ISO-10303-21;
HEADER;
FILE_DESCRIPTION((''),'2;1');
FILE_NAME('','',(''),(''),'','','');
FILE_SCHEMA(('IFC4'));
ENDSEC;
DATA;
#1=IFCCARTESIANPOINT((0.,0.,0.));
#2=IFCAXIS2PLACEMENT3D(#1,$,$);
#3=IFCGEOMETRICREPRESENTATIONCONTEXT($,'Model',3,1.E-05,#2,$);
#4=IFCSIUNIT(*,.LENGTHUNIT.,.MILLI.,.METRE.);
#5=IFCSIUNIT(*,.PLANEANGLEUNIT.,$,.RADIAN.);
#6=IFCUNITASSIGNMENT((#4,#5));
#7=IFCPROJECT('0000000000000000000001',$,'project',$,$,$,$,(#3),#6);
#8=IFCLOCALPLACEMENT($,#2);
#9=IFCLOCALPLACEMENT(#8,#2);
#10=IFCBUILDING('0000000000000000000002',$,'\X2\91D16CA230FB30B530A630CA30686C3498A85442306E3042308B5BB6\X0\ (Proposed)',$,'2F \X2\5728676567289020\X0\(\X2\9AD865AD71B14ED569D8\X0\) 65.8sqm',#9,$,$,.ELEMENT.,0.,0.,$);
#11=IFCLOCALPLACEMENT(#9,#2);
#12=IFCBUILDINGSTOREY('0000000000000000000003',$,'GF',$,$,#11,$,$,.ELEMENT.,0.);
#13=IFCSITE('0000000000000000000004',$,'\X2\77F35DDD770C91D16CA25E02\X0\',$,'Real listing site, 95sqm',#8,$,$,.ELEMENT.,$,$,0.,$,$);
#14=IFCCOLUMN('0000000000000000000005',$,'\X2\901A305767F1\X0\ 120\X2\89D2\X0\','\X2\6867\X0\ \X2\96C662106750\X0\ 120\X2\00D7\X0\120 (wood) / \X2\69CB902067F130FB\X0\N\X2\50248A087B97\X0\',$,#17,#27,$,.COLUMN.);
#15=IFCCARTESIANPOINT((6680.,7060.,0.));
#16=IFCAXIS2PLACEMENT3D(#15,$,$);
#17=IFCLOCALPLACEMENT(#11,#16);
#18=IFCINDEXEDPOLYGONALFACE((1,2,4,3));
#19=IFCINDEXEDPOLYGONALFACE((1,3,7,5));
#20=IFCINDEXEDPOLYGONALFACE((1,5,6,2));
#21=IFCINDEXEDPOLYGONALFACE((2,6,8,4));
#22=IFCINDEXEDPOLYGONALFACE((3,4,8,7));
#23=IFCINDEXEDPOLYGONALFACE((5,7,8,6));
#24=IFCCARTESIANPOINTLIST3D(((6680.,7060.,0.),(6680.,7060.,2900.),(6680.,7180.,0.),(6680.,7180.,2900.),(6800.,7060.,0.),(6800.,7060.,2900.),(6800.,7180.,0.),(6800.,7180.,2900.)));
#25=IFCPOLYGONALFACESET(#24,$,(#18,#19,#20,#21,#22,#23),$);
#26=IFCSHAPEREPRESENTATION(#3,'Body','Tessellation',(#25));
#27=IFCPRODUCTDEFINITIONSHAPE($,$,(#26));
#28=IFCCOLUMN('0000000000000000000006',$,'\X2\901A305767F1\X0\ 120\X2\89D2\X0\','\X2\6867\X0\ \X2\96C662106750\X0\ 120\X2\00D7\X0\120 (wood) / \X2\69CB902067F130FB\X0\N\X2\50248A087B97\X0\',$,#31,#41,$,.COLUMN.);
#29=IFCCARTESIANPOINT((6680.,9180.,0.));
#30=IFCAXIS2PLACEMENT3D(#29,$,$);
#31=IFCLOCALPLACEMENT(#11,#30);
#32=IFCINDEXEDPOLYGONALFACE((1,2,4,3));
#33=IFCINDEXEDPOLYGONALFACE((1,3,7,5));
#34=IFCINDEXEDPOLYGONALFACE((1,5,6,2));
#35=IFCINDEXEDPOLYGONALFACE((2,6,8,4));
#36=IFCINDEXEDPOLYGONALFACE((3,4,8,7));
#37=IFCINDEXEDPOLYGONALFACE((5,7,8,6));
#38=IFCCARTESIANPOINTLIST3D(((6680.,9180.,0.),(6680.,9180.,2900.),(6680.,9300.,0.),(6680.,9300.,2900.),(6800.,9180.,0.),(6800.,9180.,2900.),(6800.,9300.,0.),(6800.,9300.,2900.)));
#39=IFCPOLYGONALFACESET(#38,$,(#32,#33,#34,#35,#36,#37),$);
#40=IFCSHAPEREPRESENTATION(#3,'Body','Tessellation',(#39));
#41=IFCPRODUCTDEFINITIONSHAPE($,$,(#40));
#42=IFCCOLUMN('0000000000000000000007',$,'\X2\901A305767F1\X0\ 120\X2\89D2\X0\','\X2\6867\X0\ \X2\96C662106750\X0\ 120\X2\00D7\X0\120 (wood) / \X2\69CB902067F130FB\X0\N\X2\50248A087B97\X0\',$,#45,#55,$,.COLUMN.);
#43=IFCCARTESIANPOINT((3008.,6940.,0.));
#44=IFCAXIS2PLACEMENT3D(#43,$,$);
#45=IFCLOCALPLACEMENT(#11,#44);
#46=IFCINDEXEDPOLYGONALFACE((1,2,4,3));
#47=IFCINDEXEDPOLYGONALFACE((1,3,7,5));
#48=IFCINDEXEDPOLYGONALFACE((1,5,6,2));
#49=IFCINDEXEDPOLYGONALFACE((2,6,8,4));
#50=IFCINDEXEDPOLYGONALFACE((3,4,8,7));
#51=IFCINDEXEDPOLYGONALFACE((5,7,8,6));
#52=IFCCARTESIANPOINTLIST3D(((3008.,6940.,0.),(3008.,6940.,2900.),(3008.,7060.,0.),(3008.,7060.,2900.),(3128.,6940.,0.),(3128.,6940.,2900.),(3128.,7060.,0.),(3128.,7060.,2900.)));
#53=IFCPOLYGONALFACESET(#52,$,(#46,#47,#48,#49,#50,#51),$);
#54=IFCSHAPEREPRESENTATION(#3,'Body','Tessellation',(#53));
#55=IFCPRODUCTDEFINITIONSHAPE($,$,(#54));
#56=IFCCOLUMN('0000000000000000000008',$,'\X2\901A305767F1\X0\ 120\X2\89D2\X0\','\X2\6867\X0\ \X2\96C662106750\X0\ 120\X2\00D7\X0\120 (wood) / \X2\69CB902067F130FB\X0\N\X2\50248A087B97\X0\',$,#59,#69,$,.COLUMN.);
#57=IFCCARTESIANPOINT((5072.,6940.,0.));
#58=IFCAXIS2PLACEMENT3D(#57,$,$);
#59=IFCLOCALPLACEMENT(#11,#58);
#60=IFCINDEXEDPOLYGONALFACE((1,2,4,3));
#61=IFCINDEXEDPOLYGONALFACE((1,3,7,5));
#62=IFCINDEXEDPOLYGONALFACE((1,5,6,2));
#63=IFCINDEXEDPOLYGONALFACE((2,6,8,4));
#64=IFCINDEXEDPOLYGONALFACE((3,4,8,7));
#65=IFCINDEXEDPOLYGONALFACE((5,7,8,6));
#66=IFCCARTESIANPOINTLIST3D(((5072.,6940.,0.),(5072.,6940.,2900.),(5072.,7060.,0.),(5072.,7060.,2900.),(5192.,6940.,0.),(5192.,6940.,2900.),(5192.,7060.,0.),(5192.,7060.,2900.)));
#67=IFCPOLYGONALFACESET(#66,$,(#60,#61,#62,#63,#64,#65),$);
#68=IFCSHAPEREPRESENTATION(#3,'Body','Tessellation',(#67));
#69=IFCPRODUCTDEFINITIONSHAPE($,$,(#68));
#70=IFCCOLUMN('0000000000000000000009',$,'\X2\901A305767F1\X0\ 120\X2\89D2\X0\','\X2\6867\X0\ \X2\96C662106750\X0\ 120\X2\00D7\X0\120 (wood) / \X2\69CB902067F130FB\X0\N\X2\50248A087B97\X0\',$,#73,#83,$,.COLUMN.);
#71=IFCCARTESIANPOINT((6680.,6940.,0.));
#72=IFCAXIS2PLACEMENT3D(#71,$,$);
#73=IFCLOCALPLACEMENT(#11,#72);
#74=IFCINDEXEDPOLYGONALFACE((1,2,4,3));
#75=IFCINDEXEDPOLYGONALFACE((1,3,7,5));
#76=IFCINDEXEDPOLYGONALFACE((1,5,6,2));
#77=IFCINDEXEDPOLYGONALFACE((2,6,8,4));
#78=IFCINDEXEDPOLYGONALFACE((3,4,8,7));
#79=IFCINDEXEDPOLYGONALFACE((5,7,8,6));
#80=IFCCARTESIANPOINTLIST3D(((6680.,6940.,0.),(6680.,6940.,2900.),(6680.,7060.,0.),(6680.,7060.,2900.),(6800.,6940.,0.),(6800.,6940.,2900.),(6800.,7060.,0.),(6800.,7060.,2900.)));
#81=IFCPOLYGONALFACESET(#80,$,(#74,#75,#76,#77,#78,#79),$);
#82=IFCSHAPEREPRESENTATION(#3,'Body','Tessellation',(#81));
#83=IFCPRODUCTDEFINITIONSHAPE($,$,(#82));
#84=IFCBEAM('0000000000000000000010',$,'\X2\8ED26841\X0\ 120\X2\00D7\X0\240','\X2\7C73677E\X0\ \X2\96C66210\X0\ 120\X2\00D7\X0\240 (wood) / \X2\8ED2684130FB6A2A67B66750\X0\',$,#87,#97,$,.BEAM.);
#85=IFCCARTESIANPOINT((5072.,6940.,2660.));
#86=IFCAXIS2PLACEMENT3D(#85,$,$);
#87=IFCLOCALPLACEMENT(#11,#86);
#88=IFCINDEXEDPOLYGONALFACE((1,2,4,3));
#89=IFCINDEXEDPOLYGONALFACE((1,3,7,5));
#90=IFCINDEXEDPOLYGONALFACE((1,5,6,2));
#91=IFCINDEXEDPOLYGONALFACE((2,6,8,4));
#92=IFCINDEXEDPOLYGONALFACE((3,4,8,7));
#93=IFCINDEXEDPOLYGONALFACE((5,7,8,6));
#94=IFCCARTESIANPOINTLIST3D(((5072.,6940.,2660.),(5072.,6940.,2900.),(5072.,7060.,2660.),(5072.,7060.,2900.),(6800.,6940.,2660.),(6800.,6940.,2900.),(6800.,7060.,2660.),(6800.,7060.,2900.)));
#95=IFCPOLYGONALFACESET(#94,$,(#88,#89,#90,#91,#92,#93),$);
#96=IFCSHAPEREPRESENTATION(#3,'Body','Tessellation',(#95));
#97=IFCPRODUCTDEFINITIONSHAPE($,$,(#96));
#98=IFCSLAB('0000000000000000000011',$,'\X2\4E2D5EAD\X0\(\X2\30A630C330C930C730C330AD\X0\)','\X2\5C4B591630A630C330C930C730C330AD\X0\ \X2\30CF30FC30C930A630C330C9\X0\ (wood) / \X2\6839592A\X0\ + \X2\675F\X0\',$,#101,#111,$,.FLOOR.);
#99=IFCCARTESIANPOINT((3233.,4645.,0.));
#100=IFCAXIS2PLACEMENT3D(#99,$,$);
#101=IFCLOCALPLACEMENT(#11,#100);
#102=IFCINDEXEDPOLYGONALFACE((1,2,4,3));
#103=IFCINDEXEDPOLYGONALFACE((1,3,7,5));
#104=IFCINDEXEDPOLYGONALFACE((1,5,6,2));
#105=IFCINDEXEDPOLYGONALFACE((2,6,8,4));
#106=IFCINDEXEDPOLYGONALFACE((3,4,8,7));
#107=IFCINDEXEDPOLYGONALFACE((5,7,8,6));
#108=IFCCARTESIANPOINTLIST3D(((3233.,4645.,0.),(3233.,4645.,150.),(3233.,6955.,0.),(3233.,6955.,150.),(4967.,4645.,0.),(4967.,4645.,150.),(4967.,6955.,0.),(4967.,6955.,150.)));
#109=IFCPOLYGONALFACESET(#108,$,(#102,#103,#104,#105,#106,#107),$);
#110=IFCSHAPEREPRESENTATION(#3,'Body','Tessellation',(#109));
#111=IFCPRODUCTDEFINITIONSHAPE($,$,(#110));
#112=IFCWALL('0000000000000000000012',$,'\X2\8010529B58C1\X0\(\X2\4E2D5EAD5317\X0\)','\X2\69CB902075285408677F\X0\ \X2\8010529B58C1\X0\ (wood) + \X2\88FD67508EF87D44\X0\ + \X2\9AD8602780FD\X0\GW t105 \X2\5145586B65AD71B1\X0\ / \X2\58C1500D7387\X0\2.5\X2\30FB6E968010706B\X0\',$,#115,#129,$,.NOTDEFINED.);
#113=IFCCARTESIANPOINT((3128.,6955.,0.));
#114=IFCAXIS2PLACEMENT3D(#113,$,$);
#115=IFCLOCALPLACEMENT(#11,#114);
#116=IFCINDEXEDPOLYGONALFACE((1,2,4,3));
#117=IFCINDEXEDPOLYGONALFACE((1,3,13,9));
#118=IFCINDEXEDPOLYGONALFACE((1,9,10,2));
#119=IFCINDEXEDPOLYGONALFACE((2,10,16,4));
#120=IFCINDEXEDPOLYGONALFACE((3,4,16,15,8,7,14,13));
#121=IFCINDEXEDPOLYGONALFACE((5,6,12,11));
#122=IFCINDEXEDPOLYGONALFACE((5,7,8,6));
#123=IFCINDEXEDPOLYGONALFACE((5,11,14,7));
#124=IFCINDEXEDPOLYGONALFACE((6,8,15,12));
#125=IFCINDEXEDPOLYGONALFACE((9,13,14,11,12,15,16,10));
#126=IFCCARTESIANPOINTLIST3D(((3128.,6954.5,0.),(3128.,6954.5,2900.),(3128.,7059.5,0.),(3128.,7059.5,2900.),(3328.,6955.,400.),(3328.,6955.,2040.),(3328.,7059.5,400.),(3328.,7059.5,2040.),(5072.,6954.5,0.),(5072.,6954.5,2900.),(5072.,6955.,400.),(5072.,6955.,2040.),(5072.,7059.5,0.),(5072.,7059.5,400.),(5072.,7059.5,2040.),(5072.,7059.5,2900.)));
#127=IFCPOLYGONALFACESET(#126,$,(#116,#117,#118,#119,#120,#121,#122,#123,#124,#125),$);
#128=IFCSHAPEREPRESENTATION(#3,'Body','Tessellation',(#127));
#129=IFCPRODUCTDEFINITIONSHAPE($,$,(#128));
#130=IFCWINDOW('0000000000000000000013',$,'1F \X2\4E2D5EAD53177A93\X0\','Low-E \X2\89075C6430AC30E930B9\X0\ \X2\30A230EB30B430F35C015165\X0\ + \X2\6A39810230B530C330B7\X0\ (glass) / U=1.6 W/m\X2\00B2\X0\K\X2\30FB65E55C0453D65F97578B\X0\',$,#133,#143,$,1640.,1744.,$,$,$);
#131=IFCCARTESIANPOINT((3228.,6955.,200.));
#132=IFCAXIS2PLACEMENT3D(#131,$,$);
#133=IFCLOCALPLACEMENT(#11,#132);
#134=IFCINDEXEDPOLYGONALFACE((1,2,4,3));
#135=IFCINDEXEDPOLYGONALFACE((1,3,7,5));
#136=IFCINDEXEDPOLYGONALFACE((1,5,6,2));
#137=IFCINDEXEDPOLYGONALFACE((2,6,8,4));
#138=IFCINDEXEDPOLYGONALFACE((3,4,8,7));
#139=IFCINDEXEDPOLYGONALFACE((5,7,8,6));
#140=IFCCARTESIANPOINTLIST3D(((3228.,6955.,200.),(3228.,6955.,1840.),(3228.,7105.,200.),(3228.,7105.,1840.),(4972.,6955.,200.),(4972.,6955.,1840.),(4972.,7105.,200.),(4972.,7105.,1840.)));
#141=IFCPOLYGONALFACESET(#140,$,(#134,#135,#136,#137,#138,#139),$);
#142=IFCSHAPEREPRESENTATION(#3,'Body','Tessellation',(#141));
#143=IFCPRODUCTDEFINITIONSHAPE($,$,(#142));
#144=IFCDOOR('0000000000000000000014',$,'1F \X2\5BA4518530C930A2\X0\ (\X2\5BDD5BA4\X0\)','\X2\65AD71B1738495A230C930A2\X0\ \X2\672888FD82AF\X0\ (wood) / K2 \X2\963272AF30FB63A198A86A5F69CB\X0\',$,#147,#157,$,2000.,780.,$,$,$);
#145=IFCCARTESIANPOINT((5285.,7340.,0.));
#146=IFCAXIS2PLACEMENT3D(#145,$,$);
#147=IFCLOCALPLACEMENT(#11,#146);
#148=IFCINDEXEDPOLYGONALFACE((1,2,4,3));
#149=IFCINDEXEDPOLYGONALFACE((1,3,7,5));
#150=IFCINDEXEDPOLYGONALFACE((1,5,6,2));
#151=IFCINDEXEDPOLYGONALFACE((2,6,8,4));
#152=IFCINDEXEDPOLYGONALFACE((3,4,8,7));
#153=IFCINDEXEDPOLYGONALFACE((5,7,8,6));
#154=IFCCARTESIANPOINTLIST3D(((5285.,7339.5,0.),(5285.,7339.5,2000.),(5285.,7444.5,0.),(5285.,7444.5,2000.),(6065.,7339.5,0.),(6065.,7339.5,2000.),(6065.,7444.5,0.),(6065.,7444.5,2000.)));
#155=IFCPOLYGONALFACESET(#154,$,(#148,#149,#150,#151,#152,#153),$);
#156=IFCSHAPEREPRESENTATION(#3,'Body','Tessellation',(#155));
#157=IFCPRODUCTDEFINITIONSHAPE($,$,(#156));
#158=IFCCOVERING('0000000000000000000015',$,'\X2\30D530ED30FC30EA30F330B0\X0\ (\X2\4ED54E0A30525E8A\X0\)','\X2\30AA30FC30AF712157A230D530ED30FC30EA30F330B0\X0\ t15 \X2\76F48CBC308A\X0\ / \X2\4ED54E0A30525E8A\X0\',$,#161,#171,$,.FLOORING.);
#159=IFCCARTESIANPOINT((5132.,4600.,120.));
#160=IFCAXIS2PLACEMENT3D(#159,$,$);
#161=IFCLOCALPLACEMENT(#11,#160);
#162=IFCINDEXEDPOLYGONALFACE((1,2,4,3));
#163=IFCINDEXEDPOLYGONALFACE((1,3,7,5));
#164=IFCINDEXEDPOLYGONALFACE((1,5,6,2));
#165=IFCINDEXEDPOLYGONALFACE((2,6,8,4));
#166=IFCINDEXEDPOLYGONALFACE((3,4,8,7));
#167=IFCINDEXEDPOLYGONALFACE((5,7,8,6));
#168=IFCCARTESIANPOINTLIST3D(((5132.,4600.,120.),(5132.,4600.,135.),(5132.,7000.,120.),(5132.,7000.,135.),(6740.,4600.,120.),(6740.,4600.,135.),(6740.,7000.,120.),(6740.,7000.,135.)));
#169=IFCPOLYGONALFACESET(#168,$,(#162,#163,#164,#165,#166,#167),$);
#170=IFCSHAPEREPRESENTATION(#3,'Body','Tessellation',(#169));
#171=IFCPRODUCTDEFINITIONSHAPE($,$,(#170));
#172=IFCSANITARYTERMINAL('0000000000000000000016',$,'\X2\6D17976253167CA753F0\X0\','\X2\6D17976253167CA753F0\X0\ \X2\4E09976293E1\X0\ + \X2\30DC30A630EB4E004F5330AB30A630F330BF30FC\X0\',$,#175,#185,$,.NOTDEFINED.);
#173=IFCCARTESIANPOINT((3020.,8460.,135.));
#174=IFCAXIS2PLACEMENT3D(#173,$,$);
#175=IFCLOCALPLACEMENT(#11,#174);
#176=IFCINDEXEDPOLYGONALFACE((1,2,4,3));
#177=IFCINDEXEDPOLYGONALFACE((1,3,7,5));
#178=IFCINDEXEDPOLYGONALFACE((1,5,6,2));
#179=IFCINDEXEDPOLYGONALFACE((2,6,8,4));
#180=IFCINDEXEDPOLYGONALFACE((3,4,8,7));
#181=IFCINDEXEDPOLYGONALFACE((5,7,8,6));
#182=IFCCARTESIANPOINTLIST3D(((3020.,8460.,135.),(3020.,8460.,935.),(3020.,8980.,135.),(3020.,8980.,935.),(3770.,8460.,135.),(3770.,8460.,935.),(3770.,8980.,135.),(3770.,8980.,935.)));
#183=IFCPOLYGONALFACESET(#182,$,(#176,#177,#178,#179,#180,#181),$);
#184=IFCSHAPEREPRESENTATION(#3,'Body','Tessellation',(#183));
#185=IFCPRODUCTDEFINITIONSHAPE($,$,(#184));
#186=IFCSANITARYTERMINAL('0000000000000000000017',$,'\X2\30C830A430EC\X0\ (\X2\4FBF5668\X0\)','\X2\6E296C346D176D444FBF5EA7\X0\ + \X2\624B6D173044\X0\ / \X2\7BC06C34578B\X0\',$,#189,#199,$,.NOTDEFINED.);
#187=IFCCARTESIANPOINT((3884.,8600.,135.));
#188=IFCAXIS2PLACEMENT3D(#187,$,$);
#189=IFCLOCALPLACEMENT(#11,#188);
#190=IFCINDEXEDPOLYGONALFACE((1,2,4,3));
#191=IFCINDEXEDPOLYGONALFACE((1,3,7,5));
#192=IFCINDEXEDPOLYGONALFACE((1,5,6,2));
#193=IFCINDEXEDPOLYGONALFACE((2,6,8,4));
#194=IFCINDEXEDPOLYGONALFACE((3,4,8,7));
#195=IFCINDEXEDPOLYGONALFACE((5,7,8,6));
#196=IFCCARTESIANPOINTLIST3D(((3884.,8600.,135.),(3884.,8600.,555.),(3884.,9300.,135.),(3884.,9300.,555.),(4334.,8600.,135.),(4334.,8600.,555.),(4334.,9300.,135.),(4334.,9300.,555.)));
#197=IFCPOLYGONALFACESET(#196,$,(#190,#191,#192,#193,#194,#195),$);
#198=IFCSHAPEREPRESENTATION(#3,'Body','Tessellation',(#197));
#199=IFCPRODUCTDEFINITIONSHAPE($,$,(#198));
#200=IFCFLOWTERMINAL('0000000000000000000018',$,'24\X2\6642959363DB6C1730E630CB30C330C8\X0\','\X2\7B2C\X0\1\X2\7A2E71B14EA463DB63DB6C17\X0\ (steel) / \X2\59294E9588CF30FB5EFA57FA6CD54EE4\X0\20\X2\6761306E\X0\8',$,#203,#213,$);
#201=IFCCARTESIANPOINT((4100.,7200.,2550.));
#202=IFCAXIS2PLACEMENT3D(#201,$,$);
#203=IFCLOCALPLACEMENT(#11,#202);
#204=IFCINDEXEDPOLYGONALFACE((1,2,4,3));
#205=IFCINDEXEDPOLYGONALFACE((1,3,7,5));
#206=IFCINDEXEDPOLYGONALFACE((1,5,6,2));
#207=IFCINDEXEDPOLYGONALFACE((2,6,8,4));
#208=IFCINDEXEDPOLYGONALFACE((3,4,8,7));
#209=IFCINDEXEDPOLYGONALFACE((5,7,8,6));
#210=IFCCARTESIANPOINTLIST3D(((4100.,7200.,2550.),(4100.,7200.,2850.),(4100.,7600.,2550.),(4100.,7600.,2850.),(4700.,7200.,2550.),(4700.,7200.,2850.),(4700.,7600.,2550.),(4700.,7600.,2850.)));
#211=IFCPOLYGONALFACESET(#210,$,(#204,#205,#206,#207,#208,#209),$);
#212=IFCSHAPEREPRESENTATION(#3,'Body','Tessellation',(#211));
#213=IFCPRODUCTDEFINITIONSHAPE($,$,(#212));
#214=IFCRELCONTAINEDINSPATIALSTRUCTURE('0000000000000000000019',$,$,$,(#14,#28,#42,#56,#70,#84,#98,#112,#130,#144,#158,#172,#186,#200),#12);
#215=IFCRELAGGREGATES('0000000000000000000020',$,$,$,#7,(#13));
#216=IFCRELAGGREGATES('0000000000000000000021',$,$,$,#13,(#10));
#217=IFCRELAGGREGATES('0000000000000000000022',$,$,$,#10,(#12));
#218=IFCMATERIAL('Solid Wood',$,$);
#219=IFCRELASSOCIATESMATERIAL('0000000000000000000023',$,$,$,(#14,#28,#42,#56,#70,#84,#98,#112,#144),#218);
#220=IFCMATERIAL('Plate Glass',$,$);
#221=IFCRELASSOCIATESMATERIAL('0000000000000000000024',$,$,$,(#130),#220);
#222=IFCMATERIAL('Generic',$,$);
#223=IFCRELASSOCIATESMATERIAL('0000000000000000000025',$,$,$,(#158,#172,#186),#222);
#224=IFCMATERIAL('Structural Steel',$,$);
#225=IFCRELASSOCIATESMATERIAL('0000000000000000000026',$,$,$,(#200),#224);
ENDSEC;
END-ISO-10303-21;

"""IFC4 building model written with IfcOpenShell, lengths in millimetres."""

from ifc_helpers import new_model, si_unit, frame, frame_2d, origin, place, context, project, spatial, rectangle, extrude, material, element, fill, save


model = new_model("IFC4")

# Units and contexts
model_context = context("Model", 3, precision=1e-05, world=origin())
ifc_project = project(units=[si_unit("LENGTHUNIT", "METRE", prefix="MILLI"), si_unit("PLANEANGLEUNIT", "RADIAN")], contexts=[model_context])

# Site, building, storey
site_placement = place(None, origin())
site = spatial("IfcSite", under=ifc_project, at=site_placement, Name="石川県金沢市", ObjectType="Real listing site, 95sqm", CompositionType="ELEMENT", RefElevation=0.0)
building_placement = place(site_placement, origin())
building = spatial("IfcBuilding", under=site, at=building_placement, Name="金沢・サウナと水風呂のある家 (Proposed)", ObjectType="2F 在来木造(高断熱仕様) 65.8sqm", CompositionType="ELEMENT", ElevationOfRefHeight=0.0, ElevationOfTerrain=0.0)
storey_placement = place(building_placement, origin())
storey = spatial("IfcBuildingStorey", under=building, at=storey_placement, Name="GF", CompositionType="ELEMENT", Elevation=0.0)

# Columns
ifc_material_1 = material(Name="Solid Wood")
column_1_placement = place(storey_placement, frame((6680.0, 7060.0, 0.0)))
element("IfcColumn", 1, at=column_1_placement, inside=storey, material=ifc_material_1, Name="通し柱 120角", Description="桧 集成材 120×120 (wood) / 構造柱・N値計算", PredefinedType="COLUMN", context=model_context, shape_type="SweptSolid", body=[
    extrude(rectangle(XDim=120.0, YDim=120.0, at=frame_2d((60.0, 60.0))), frame((6680.0, 7060.0, 0.0)), (0.0, 0.0, 1.0), 2900.0),
])
column_2_placement = place(storey_placement, frame((6680.0, 9180.0, 0.0)))
element("IfcColumn", 2, at=column_2_placement, inside=storey, material=ifc_material_1, Name="通し柱 120角", Description="桧 集成材 120×120 (wood) / 構造柱・N値計算", PredefinedType="COLUMN", context=model_context, shape_type="SweptSolid", body=[
    extrude(rectangle(XDim=120.0, YDim=120.0, at=frame_2d((60.0, 60.0))), frame((6680.0, 9180.0, 0.0)), (0.0, 0.0, 1.0), 2900.0),
])
column_3_placement = place(storey_placement, frame((3008.0, 6940.0, 0.0)))
element("IfcColumn", 3, at=column_3_placement, inside=storey, material=ifc_material_1, Name="通し柱 120角", Description="桧 集成材 120×120 (wood) / 構造柱・N値計算", PredefinedType="COLUMN", context=model_context, shape_type="SweptSolid", body=[
    extrude(rectangle(XDim=120.0, YDim=120.0, at=frame_2d((60.0, 60.0))), frame((3008.0, 6940.0, 0.0)), (0.0, 0.0, 1.0), 2900.0),
])
column_4_placement = place(storey_placement, frame((5072.0, 6940.0, 0.0)))
element("IfcColumn", 4, at=column_4_placement, inside=storey, material=ifc_material_1, Name="通し柱 120角", Description="桧 集成材 120×120 (wood) / 構造柱・N値計算", PredefinedType="COLUMN", context=model_context, shape_type="SweptSolid", body=[
    extrude(rectangle(XDim=120.0, YDim=120.0, at=frame_2d((60.0, 60.0))), frame((5072.0, 6940.0, 0.0)), (0.0, 0.0, 1.0), 2900.0),
])
column_5_placement = place(storey_placement, frame((6680.0, 6940.0, 0.0)))
element("IfcColumn", 5, at=column_5_placement, inside=storey, material=ifc_material_1, Name="通し柱 120角", Description="桧 集成材 120×120 (wood) / 構造柱・N値計算", PredefinedType="COLUMN", context=model_context, shape_type="SweptSolid", body=[
    extrude(rectangle(XDim=120.0, YDim=120.0, at=frame_2d((60.0, 60.0))), frame((6680.0, 6940.0, 0.0)), (0.0, 0.0, 1.0), 2900.0),
])

# Beam
beam_1_placement = place(storey_placement, frame((5072.0, 6940.0, 2660.0)))
element("IfcBeam", 6, at=beam_1_placement, inside=storey, material=ifc_material_1, Name="軒桁 120×240", Description="米松 集成 120×240 (wood) / 軒桁・横架材", PredefinedType="BEAM", context=model_context, shape_type="SweptSolid", body=[
    extrude(rectangle(XDim=1728.0, YDim=120.0, at=frame_2d((864.0, 60.0))), frame((5072.0, 6940.0, 2660.0)), (0.0, 0.0, 1.0), 240.0),
])

# Slab
slab_placement = place(storey_placement, frame((3233.0, 4645.0, 0.0)))
element("IfcSlab", 7, at=slab_placement, inside=storey, material=ifc_material_1, Name="中庭(ウッドデッキ)", Description="屋外ウッドデッキ ハードウッド (wood) / 根太 + 束", PredefinedType="FLOOR", context=model_context, shape_type="SweptSolid", body=[
    extrude(rectangle(XDim=1734.0, YDim=2310.0, at=frame_2d((867.0, 1155.0))), frame((3233.0, 4645.0, 0.0)), (0.0, 0.0, 1.0), 150.0),
])

# Wall, opening, window
wall_1_placement = place(storey_placement, frame((3128.0, 6955.0, 0.0)))
wall_1 = element("IfcWall", 8, at=wall_1_placement, inside=storey, material=ifc_material_1, Name="耐力壁(中庭北)", Description="構造用合板 耐力壁 (wood) + 製材軸組 + 高性能GW t105 充填断熱 / 壁倍率2.5・準耐火", PredefinedType="NOTDEFINED", context=model_context, shape_type="SweptSolid", body=[
    extrude(rectangle(XDim=1944.0, YDim=105.0, at=frame_2d((972.0, 52.0))), frame((3128.0, 6955.0, 0.0)), (0.0, 0.0, 1.0), 2900.0),
])
opening_placement = place(storey_placement, frame((3228.0, 6955.0, 200.0)))
opening = element("IfcOpeningElement", 9, at=opening_placement, cuts=wall_1, PredefinedType="NOTDEFINED", context=model_context, shape_type="SweptSolid", body=[
    extrude(rectangle(XDim=1744.0, YDim=150.0, at=frame_2d((872.0, 75.0))), frame((3228.0, 6955.0, 200.0)), (0.0, 0.0, 1.0), 1640.0),
])
ifc_material_2 = material(Name="Plate Glass")
window_placement = place(storey_placement, frame((3228.0, 6955.0, 200.0)))
window = element("IfcWindow", 10, at=window_placement, inside=storey, material=ifc_material_2, Name="1F 中庭北窓", Description="Low-E 複層ガラス アルゴン封入 + 樹脂サッシ (glass) / U=1.6 W/m²K・日射取得型", OverallHeight=1640.0, OverallWidth=1744.0, context=model_context, shape_type="SweptSolid", body=[
    extrude(rectangle(XDim=1744.0, YDim=150.0, at=frame_2d((872.0, 75.0))), frame((3228.0, 6955.0, 200.0)), (0.0, 0.0, 1.0), 1640.0),
])
fill(opening, window)

# Door
door_placement = place(storey_placement, frame((5285.0, 7340.0, 0.0)))
element("IfcDoor", 11, at=door_placement, inside=storey, material=ifc_material_1, Name="1F 室内ドア (寝室)", Description="断熱玄関ドア 木製芯 (wood) / K2 防犯・採風機構", OverallHeight=2000.0, OverallWidth=780.0, context=model_context, shape_type="SweptSolid", body=[
    extrude(rectangle(XDim=780.0, YDim=105.0, at=frame_2d((390.0, 52.0))), frame((5285.0, 7340.0, 0.0)), (0.0, 0.0, 1.0), 2000.0),
])

# Covering
ifc_material_3 = material(Name="Generic")
covering_placement = place(storey_placement, frame((5132.0, 4600.0, 120.0)))
element("IfcCovering", 12, at=covering_placement, inside=storey, material=ifc_material_3, Name="フローリング (仕上げ床)", Description="オーク無垢フローリング t15 直貼り / 仕上げ床", PredefinedType="FLOORING", context=model_context, shape_type="SweptSolid", body=[
    extrude(rectangle(XDim=1608.0, YDim=2400.0, at=frame_2d((804.0, 1200.0))), frame((5132.0, 4600.0, 120.0)), (0.0, 0.0, 1.0), 15.0),
])

# Sanitary terminals
sanitary_terminal_1_placement = place(storey_placement, frame((3020.0, 8460.0, 135.0)))
element("IfcSanitaryTerminal", 13, at=sanitary_terminal_1_placement, inside=storey, material=ifc_material_3, Name="洗面化粧台", Description="洗面化粧台 三面鏡 + ボウル一体カウンター", PredefinedType="NOTDEFINED", context=model_context, shape_type="SweptSolid", body=[
    extrude(rectangle(XDim=750.0, YDim=520.0, at=frame_2d((375.0, 260.0))), frame((3020.0, 8460.0, 135.0)), (0.0, 0.0, 1.0), 800.0),
])
sanitary_terminal_2_placement = place(storey_placement, frame((3884.0, 8600.0, 135.0)))
element("IfcSanitaryTerminal", 14, at=sanitary_terminal_2_placement, inside=storey, material=ifc_material_3, Name="トイレ (便器)", Description="温水洗浄便座 + 手洗い / 節水型", PredefinedType="NOTDEFINED", context=model_context, shape_type="SweptSolid", body=[
    extrude(rectangle(XDim=450.0, YDim=700.0, at=frame_2d((225.0, 350.0))), frame((3884.0, 8600.0, 135.0)), (0.0, 0.0, 1.0), 420.0),
])

# Flow terminal
ifc_material_4 = material(Name="Structural Steel")
flow_terminal_placement = place(storey_placement, frame((4100.0, 7200.0, 2550.0)))
element("IfcFlowTerminal", 15, at=flow_terminal_placement, inside=storey, material=ifc_material_4, Name="24時間換気ユニット", Description="第1種熱交換換気 (steel) / 天井裏・建基法令20条の8", context=model_context, shape_type="SweptSolid", body=[
    extrude(rectangle(XDim=600.0, YDim=400.0, at=frame_2d((300.0, 200.0))), frame((4100.0, 7200.0, 2550.0)), (0.0, 0.0, 1.0), 300.0),
])

save(model, "model.ifc")
